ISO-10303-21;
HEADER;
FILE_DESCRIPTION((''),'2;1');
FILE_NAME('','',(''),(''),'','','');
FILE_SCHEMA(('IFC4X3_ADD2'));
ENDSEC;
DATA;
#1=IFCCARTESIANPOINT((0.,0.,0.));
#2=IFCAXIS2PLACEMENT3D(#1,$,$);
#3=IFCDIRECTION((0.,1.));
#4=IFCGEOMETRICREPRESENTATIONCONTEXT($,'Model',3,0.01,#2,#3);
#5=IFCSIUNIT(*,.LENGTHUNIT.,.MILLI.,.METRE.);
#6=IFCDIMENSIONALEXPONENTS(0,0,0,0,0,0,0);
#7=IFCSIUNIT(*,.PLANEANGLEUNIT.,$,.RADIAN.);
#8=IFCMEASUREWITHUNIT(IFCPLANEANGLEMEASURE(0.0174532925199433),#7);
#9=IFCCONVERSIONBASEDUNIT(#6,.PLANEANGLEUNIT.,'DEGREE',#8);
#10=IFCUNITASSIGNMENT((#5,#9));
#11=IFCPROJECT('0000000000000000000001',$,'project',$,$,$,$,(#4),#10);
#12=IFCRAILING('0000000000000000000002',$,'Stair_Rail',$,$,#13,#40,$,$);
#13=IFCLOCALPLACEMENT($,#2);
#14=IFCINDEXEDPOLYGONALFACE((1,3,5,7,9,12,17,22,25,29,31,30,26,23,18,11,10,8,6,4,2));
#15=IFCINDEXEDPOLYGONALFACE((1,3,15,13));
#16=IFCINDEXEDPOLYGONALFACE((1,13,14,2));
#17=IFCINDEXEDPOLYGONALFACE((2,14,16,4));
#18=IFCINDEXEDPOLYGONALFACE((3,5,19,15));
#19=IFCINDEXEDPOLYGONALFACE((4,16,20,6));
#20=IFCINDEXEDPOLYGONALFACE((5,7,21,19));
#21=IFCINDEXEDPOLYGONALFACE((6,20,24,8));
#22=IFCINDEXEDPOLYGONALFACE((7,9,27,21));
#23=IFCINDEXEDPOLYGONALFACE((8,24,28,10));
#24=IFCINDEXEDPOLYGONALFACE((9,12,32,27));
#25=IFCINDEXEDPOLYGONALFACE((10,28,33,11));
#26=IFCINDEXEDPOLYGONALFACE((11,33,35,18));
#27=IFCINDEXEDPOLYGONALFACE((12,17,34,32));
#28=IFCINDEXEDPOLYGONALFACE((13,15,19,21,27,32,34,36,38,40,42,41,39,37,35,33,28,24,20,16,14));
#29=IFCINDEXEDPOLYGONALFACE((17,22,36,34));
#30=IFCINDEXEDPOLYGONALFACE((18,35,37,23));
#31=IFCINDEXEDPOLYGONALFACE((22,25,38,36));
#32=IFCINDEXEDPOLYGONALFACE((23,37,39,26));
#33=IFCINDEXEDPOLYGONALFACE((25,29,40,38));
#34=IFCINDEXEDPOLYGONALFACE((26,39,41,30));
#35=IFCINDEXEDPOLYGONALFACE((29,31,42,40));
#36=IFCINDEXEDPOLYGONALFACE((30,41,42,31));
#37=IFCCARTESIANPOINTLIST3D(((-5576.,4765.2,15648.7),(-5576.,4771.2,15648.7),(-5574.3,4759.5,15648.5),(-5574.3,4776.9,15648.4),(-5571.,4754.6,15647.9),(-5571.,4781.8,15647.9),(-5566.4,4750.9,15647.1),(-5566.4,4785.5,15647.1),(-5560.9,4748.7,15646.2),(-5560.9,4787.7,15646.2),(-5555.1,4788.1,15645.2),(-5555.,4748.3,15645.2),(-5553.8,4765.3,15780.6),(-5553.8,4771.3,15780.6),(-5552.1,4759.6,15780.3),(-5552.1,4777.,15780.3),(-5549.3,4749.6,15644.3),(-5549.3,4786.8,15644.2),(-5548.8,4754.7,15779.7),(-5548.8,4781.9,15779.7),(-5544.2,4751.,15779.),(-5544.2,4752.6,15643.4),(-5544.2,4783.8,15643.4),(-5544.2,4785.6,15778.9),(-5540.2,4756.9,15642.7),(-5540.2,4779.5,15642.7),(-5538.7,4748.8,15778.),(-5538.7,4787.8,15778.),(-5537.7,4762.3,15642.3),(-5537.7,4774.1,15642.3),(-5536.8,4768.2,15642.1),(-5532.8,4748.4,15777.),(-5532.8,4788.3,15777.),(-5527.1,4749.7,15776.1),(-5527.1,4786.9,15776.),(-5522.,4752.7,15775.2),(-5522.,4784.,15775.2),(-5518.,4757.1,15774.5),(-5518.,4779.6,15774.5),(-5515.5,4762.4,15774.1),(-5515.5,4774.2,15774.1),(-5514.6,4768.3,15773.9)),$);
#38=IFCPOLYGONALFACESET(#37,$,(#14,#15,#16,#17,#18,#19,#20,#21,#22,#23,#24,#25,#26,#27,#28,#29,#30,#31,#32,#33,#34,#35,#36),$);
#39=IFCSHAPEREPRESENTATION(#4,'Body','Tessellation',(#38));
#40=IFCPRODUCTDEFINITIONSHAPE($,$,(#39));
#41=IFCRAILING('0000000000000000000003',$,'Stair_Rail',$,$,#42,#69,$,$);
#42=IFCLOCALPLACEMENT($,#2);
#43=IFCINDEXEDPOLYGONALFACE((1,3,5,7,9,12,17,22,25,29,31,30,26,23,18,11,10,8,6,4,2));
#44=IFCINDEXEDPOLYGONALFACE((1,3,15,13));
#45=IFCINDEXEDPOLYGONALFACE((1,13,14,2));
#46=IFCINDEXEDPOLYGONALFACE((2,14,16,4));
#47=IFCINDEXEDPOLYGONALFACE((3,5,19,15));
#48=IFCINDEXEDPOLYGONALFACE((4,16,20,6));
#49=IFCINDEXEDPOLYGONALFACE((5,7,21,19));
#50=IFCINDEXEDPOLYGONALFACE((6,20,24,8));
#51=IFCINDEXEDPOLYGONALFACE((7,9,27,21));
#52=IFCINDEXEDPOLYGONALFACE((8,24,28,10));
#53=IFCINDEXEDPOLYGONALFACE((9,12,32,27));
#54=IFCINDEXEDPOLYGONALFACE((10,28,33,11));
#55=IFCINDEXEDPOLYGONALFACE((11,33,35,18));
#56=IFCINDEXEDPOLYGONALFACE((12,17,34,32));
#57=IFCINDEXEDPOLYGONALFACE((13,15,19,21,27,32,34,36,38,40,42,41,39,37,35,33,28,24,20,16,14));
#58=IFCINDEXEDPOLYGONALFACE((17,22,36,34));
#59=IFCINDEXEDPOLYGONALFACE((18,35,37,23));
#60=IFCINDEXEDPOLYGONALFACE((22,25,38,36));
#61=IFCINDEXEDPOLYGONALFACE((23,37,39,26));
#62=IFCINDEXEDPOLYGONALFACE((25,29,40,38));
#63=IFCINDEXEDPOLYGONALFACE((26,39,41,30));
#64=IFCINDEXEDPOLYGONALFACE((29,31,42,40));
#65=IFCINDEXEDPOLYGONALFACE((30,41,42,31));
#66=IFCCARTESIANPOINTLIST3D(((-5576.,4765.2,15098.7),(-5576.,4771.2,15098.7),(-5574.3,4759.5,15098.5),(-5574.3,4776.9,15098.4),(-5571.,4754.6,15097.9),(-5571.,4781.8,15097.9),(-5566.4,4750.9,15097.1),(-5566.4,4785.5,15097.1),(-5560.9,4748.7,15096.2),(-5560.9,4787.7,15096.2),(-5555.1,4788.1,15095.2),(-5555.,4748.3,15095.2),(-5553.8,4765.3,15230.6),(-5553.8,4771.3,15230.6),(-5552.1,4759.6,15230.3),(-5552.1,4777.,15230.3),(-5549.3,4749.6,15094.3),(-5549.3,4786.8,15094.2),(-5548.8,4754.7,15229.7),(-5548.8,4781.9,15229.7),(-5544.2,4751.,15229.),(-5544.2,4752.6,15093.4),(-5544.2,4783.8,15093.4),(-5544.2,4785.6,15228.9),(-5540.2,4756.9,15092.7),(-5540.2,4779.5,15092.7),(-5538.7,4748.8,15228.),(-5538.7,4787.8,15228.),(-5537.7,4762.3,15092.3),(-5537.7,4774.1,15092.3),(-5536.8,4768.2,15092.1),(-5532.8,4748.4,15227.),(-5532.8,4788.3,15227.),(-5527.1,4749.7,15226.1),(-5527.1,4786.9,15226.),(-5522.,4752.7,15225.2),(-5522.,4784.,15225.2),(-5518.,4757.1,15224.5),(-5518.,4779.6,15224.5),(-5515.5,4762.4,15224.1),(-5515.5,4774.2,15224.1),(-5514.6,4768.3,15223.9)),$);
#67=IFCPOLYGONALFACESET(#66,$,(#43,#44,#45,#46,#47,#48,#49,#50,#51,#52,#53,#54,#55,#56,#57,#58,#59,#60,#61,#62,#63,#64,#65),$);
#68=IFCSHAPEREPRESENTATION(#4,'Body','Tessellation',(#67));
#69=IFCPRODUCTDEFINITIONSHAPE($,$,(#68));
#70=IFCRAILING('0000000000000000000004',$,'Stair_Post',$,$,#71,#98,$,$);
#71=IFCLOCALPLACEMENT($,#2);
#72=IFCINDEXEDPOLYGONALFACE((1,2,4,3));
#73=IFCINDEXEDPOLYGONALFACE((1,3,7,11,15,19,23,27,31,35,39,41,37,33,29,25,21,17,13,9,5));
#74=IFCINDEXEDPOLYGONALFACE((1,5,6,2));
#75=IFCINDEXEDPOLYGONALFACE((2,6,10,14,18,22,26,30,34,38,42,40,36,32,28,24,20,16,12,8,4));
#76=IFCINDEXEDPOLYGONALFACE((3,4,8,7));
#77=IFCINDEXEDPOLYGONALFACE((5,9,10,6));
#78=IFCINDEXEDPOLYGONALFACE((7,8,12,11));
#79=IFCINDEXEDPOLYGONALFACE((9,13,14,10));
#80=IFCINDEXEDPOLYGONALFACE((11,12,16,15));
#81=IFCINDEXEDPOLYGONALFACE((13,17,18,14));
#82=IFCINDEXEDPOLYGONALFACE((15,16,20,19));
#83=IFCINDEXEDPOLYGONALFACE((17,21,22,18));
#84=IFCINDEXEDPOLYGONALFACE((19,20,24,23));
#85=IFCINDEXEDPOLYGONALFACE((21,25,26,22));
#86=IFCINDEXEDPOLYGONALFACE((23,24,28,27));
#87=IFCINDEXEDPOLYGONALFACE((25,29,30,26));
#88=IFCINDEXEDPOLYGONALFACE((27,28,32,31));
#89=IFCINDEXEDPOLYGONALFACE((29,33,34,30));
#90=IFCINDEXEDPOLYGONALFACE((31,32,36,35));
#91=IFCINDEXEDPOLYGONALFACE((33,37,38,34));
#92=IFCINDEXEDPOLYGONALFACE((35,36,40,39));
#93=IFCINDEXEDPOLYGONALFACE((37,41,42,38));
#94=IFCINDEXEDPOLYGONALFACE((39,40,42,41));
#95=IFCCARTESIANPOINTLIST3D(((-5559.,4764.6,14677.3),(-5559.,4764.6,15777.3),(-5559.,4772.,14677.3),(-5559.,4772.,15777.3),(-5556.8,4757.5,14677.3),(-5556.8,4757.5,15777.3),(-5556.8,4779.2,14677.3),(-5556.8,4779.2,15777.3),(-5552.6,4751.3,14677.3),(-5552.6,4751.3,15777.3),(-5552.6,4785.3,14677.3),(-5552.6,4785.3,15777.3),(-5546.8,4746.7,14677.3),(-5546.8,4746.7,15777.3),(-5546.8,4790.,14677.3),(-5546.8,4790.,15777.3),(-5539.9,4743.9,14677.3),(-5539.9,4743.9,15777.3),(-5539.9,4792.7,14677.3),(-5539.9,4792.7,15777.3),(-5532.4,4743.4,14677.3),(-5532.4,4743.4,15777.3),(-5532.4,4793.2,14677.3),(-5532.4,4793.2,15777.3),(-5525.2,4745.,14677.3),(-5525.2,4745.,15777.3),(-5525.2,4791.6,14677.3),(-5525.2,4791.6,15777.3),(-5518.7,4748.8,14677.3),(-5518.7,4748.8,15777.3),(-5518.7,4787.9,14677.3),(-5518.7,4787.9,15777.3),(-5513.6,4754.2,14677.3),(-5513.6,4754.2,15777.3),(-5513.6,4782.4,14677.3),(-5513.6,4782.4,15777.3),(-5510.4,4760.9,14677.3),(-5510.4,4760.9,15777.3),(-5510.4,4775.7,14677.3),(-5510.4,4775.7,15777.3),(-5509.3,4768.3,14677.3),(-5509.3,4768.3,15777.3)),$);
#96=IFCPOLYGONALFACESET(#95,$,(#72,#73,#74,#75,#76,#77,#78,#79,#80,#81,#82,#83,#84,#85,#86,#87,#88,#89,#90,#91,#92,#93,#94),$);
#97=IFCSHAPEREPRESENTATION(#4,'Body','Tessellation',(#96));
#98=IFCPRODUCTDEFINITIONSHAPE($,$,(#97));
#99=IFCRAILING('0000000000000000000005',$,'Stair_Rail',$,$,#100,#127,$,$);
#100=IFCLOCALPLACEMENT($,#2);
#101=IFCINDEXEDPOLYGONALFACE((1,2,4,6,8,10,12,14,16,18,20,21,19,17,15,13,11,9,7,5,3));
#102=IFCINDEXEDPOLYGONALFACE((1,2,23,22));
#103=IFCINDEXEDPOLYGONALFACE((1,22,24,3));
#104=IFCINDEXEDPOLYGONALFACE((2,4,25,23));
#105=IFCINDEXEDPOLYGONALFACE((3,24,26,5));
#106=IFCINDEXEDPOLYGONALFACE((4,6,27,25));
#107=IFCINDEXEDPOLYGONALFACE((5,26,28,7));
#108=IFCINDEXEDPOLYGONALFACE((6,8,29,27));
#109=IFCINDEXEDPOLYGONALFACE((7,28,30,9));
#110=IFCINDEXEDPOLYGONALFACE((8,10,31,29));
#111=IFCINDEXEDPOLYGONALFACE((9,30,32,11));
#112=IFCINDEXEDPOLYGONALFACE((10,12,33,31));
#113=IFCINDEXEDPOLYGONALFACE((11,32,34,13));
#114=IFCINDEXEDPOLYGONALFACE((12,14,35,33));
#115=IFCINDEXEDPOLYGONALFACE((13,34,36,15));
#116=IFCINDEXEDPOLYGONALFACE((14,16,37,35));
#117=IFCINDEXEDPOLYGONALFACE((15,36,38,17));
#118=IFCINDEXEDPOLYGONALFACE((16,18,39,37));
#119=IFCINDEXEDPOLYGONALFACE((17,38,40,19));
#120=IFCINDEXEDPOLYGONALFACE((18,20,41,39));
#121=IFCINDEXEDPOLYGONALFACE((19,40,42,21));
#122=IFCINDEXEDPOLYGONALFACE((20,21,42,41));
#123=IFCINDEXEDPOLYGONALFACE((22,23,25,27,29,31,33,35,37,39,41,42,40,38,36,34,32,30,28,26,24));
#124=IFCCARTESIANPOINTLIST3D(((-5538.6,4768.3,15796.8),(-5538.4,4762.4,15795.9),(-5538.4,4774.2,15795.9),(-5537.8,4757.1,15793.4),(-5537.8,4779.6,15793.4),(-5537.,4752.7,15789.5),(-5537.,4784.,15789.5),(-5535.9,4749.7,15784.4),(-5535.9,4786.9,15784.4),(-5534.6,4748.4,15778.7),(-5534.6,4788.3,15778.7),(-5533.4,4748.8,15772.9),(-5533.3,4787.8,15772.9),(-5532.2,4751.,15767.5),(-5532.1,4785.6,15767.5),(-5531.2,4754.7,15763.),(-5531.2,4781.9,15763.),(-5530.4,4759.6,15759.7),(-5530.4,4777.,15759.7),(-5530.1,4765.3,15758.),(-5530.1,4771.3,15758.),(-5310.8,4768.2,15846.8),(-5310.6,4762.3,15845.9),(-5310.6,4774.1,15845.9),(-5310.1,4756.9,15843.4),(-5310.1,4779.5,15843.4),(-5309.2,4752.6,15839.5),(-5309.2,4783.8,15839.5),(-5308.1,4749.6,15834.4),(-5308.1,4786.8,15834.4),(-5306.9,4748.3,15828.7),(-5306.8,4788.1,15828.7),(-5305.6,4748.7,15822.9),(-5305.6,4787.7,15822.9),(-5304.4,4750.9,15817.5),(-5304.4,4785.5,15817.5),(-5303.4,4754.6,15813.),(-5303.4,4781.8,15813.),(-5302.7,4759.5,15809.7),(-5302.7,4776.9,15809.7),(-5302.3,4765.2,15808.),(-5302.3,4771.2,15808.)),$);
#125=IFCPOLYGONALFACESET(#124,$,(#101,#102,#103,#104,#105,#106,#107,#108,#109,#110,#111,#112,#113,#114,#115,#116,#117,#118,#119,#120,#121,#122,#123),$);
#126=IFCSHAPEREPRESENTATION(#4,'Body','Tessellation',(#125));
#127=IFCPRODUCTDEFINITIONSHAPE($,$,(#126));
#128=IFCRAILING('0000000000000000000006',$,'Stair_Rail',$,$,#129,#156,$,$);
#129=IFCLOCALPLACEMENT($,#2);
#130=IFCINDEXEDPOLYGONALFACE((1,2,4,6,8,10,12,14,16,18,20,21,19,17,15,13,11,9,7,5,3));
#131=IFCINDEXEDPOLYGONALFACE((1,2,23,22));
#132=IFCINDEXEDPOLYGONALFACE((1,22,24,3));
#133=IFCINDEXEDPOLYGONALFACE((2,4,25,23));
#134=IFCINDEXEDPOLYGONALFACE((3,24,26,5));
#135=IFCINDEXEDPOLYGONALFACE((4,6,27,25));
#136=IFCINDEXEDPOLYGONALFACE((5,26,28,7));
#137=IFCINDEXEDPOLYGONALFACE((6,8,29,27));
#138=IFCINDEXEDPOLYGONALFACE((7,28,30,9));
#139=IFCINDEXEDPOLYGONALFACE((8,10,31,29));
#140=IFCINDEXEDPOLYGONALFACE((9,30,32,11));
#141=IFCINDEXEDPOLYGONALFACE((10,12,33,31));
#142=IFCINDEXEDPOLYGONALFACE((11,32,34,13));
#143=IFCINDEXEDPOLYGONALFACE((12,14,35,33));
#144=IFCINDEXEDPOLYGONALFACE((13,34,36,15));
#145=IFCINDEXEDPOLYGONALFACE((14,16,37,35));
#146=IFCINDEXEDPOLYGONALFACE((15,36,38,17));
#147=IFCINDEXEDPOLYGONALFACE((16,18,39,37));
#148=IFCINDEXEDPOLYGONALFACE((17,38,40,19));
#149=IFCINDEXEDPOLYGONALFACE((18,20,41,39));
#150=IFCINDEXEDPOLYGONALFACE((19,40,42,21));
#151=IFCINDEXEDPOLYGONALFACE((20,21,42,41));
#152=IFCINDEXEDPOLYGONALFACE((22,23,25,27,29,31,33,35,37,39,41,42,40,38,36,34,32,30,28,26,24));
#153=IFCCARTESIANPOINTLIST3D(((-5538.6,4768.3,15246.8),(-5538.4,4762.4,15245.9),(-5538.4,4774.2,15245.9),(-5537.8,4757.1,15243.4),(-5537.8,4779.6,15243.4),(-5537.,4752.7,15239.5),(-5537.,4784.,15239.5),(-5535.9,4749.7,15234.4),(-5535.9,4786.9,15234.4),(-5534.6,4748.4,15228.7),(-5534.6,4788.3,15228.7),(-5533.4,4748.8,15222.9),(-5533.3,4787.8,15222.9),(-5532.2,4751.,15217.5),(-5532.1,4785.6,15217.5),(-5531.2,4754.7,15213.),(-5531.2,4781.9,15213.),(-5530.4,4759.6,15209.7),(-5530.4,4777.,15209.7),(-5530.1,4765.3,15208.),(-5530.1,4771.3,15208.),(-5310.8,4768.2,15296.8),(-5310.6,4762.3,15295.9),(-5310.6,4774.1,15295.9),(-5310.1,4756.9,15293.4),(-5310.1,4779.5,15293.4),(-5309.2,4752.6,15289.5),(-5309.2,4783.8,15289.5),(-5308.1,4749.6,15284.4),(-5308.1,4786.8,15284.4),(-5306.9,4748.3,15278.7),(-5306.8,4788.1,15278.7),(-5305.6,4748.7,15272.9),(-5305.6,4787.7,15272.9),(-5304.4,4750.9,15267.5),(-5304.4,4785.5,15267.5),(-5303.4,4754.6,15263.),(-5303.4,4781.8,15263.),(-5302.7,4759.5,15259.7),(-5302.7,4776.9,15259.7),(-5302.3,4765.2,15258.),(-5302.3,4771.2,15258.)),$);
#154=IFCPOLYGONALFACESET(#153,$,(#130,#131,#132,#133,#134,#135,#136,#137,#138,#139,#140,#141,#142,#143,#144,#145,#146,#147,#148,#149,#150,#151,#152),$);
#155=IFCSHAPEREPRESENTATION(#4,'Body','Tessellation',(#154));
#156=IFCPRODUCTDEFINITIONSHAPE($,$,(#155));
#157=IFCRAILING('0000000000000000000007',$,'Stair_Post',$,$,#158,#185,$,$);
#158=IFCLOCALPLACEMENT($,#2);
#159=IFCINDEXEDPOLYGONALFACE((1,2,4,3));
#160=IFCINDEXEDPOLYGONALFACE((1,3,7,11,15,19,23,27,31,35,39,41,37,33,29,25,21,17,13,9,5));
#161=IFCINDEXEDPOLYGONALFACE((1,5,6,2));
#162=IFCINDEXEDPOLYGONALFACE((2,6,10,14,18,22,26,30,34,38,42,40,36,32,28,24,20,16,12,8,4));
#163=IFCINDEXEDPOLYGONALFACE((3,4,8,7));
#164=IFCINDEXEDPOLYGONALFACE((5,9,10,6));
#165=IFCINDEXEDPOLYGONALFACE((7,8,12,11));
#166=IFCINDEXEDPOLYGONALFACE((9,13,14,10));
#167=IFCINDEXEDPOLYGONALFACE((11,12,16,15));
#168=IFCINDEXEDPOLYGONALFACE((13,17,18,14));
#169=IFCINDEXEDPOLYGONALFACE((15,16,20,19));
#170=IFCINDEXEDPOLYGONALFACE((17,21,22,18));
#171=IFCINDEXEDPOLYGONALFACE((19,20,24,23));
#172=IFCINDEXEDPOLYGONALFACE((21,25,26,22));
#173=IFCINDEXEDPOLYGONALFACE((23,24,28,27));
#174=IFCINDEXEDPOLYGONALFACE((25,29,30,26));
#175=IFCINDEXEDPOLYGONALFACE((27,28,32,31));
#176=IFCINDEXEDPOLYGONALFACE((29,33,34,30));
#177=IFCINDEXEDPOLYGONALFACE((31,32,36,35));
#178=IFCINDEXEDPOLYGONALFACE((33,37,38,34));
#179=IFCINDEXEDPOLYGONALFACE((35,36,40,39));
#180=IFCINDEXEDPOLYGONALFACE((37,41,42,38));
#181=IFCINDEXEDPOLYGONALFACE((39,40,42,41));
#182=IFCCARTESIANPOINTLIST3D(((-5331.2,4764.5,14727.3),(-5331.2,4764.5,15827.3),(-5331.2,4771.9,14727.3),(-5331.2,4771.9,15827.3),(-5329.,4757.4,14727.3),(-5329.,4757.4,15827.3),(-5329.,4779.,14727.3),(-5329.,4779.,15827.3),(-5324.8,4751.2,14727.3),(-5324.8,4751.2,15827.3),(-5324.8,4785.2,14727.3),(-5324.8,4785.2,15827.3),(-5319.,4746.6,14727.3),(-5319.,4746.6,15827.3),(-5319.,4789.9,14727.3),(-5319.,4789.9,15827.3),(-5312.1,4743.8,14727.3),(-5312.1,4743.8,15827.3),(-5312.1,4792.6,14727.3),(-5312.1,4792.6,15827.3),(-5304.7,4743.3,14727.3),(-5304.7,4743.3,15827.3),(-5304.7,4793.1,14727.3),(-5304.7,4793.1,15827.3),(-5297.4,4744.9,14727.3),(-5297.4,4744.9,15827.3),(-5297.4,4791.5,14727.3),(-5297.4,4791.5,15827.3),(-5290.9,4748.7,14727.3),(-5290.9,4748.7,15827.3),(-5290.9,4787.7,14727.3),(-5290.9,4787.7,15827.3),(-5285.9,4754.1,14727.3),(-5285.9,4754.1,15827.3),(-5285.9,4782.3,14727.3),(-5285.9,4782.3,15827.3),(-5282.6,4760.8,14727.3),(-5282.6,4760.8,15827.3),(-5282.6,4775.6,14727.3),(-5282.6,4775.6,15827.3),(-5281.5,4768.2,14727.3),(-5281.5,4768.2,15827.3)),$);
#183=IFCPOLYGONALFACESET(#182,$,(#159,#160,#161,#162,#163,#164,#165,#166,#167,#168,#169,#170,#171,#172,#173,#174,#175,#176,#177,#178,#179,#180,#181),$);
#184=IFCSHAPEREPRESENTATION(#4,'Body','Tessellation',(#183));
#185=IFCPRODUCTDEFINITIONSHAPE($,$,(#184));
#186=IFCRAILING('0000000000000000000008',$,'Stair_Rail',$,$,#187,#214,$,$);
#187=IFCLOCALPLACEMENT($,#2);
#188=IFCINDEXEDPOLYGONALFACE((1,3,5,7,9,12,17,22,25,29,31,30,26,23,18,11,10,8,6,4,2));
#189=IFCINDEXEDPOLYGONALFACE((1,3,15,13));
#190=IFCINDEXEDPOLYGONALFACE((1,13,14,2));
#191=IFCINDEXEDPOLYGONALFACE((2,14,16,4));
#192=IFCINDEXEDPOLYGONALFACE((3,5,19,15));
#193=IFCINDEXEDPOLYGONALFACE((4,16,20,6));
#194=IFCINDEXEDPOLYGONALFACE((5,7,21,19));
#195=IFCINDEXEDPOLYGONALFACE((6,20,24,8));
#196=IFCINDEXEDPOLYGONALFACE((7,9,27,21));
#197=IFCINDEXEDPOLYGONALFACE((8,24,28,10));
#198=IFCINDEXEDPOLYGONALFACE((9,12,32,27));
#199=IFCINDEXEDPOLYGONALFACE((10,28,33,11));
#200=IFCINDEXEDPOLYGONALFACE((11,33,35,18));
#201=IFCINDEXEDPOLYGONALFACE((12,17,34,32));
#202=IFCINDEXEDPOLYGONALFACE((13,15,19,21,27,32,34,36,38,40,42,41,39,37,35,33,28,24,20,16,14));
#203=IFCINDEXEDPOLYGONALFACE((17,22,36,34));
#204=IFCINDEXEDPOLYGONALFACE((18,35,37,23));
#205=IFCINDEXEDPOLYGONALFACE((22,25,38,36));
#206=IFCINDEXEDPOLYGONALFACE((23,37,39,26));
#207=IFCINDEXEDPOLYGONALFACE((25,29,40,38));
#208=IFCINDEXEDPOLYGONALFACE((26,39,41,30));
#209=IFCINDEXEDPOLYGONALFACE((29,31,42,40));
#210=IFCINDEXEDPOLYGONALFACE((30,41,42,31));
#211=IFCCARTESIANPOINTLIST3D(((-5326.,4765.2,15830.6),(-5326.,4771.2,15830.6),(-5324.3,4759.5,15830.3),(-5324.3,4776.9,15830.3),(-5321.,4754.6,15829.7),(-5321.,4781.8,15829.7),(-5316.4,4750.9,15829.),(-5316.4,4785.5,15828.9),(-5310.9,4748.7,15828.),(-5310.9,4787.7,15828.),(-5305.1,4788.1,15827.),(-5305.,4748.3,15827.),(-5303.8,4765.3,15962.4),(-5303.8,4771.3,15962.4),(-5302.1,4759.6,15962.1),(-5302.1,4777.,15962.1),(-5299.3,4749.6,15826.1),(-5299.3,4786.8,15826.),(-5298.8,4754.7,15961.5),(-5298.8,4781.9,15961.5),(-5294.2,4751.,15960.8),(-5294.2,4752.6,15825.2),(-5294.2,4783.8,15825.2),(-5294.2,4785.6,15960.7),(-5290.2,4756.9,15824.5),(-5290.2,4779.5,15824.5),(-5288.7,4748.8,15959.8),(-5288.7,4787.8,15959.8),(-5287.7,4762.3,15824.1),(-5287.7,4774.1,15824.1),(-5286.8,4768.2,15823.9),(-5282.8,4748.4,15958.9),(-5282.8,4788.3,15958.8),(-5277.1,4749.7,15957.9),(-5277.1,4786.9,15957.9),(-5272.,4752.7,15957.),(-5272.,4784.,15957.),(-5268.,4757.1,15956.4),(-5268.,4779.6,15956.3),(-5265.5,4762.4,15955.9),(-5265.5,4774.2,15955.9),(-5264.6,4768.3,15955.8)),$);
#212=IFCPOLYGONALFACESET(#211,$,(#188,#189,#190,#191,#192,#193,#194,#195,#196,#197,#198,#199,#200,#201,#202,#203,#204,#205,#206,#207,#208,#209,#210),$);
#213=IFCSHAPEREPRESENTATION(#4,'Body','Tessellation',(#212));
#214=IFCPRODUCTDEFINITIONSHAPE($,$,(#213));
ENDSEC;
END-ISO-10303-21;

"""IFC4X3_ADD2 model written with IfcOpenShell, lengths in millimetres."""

from ifc_helpers import new_model, entity, si_unit, converted_unit, direction, frame, origin, context, project, circle, extrude, element, save


model = new_model("IFC4X3_ADD2")

# Units and contexts
model_context = context("Model", 3, precision=0.01, world=origin(), true_north=direction((0.0, 1.0)))
ifc_project = project(units=[si_unit("LENGTHUNIT", "METRE", prefix="MILLI"), converted_unit("PLANEANGLEUNIT", "DEGREE", entity("IfcPlaneAngleMeasure", 0.0174532925199433), si_unit("PLANEANGLEUNIT", "RADIAN"), dimensions=[0, 0, 0, 0, 0, 0, 0])], contexts=[model_context])

# Railings
element("IfcRailing", 1, Name="Stair_Rail", context=model_context, shape_type="SweptSolid", body=[
    entity("IfcSweptDiskSolid", entity("IfcPolyline", [entity("IfcCartesianPoint", [-5556.5, 4768.2, 15645.5]), entity("IfcCartesianPoint", [-5534.3, 4768.3, 15777.3])]), 20.0),
])
element("IfcRailing", 2, Name="Stair_Rail", context=model_context, shape_type="SweptSolid", body=[
    entity("IfcSweptDiskSolid", entity("IfcPolyline", [entity("IfcCartesianPoint", [-5556.5, 4768.2, 15095.5]), entity("IfcCartesianPoint", [-5534.3, 4768.3, 15227.3])]), 20.0),
])
element("IfcRailing", 3, Name="Stair_Post", context=model_context, shape_type="SweptSolid", body=[
    extrude(circle(Radius=25.0), frame((-5534.3, 4768.3, 14677.3)), (0.0, 0.0, 1.0), 1100.0),
])
element("IfcRailing", 4, Name="Stair_Rail", context=model_context, shape_type="SweptSolid", body=[
    entity("IfcSweptDiskSolid", entity("IfcPolyline", [entity("IfcCartesianPoint", [-5534.3, 4768.3, 15777.3]), entity("IfcCartesianPoint", [-5306.5, 4768.2, 15827.3])]), 20.0),
])
element("IfcRailing", 5, Name="Stair_Rail", context=model_context, shape_type="SweptSolid", body=[
    entity("IfcSweptDiskSolid", entity("IfcPolyline", [entity("IfcCartesianPoint", [-5534.3, 4768.3, 15227.3]), entity("IfcCartesianPoint", [-5306.5, 4768.2, 15277.3])]), 20.0),
])
element("IfcRailing", 6, Name="Stair_Post", context=model_context, shape_type="SweptSolid", body=[
    extrude(circle(Radius=25.0), frame((-5306.5, 4768.2, 14727.3)), (0.0, 0.0, 1.0), 1100.0),
])
element("IfcRailing", 7, Name="Stair_Rail", context=model_context, shape_type="SweptSolid", body=[
    entity("IfcSweptDiskSolid", entity("IfcPolyline", [entity("IfcCartesianPoint", [-5306.5, 4768.2, 15827.3]), entity("IfcCartesianPoint", [-5284.3, 4768.3, 15959.1])]), 20.0),
])

save(model, "model.ifc")
